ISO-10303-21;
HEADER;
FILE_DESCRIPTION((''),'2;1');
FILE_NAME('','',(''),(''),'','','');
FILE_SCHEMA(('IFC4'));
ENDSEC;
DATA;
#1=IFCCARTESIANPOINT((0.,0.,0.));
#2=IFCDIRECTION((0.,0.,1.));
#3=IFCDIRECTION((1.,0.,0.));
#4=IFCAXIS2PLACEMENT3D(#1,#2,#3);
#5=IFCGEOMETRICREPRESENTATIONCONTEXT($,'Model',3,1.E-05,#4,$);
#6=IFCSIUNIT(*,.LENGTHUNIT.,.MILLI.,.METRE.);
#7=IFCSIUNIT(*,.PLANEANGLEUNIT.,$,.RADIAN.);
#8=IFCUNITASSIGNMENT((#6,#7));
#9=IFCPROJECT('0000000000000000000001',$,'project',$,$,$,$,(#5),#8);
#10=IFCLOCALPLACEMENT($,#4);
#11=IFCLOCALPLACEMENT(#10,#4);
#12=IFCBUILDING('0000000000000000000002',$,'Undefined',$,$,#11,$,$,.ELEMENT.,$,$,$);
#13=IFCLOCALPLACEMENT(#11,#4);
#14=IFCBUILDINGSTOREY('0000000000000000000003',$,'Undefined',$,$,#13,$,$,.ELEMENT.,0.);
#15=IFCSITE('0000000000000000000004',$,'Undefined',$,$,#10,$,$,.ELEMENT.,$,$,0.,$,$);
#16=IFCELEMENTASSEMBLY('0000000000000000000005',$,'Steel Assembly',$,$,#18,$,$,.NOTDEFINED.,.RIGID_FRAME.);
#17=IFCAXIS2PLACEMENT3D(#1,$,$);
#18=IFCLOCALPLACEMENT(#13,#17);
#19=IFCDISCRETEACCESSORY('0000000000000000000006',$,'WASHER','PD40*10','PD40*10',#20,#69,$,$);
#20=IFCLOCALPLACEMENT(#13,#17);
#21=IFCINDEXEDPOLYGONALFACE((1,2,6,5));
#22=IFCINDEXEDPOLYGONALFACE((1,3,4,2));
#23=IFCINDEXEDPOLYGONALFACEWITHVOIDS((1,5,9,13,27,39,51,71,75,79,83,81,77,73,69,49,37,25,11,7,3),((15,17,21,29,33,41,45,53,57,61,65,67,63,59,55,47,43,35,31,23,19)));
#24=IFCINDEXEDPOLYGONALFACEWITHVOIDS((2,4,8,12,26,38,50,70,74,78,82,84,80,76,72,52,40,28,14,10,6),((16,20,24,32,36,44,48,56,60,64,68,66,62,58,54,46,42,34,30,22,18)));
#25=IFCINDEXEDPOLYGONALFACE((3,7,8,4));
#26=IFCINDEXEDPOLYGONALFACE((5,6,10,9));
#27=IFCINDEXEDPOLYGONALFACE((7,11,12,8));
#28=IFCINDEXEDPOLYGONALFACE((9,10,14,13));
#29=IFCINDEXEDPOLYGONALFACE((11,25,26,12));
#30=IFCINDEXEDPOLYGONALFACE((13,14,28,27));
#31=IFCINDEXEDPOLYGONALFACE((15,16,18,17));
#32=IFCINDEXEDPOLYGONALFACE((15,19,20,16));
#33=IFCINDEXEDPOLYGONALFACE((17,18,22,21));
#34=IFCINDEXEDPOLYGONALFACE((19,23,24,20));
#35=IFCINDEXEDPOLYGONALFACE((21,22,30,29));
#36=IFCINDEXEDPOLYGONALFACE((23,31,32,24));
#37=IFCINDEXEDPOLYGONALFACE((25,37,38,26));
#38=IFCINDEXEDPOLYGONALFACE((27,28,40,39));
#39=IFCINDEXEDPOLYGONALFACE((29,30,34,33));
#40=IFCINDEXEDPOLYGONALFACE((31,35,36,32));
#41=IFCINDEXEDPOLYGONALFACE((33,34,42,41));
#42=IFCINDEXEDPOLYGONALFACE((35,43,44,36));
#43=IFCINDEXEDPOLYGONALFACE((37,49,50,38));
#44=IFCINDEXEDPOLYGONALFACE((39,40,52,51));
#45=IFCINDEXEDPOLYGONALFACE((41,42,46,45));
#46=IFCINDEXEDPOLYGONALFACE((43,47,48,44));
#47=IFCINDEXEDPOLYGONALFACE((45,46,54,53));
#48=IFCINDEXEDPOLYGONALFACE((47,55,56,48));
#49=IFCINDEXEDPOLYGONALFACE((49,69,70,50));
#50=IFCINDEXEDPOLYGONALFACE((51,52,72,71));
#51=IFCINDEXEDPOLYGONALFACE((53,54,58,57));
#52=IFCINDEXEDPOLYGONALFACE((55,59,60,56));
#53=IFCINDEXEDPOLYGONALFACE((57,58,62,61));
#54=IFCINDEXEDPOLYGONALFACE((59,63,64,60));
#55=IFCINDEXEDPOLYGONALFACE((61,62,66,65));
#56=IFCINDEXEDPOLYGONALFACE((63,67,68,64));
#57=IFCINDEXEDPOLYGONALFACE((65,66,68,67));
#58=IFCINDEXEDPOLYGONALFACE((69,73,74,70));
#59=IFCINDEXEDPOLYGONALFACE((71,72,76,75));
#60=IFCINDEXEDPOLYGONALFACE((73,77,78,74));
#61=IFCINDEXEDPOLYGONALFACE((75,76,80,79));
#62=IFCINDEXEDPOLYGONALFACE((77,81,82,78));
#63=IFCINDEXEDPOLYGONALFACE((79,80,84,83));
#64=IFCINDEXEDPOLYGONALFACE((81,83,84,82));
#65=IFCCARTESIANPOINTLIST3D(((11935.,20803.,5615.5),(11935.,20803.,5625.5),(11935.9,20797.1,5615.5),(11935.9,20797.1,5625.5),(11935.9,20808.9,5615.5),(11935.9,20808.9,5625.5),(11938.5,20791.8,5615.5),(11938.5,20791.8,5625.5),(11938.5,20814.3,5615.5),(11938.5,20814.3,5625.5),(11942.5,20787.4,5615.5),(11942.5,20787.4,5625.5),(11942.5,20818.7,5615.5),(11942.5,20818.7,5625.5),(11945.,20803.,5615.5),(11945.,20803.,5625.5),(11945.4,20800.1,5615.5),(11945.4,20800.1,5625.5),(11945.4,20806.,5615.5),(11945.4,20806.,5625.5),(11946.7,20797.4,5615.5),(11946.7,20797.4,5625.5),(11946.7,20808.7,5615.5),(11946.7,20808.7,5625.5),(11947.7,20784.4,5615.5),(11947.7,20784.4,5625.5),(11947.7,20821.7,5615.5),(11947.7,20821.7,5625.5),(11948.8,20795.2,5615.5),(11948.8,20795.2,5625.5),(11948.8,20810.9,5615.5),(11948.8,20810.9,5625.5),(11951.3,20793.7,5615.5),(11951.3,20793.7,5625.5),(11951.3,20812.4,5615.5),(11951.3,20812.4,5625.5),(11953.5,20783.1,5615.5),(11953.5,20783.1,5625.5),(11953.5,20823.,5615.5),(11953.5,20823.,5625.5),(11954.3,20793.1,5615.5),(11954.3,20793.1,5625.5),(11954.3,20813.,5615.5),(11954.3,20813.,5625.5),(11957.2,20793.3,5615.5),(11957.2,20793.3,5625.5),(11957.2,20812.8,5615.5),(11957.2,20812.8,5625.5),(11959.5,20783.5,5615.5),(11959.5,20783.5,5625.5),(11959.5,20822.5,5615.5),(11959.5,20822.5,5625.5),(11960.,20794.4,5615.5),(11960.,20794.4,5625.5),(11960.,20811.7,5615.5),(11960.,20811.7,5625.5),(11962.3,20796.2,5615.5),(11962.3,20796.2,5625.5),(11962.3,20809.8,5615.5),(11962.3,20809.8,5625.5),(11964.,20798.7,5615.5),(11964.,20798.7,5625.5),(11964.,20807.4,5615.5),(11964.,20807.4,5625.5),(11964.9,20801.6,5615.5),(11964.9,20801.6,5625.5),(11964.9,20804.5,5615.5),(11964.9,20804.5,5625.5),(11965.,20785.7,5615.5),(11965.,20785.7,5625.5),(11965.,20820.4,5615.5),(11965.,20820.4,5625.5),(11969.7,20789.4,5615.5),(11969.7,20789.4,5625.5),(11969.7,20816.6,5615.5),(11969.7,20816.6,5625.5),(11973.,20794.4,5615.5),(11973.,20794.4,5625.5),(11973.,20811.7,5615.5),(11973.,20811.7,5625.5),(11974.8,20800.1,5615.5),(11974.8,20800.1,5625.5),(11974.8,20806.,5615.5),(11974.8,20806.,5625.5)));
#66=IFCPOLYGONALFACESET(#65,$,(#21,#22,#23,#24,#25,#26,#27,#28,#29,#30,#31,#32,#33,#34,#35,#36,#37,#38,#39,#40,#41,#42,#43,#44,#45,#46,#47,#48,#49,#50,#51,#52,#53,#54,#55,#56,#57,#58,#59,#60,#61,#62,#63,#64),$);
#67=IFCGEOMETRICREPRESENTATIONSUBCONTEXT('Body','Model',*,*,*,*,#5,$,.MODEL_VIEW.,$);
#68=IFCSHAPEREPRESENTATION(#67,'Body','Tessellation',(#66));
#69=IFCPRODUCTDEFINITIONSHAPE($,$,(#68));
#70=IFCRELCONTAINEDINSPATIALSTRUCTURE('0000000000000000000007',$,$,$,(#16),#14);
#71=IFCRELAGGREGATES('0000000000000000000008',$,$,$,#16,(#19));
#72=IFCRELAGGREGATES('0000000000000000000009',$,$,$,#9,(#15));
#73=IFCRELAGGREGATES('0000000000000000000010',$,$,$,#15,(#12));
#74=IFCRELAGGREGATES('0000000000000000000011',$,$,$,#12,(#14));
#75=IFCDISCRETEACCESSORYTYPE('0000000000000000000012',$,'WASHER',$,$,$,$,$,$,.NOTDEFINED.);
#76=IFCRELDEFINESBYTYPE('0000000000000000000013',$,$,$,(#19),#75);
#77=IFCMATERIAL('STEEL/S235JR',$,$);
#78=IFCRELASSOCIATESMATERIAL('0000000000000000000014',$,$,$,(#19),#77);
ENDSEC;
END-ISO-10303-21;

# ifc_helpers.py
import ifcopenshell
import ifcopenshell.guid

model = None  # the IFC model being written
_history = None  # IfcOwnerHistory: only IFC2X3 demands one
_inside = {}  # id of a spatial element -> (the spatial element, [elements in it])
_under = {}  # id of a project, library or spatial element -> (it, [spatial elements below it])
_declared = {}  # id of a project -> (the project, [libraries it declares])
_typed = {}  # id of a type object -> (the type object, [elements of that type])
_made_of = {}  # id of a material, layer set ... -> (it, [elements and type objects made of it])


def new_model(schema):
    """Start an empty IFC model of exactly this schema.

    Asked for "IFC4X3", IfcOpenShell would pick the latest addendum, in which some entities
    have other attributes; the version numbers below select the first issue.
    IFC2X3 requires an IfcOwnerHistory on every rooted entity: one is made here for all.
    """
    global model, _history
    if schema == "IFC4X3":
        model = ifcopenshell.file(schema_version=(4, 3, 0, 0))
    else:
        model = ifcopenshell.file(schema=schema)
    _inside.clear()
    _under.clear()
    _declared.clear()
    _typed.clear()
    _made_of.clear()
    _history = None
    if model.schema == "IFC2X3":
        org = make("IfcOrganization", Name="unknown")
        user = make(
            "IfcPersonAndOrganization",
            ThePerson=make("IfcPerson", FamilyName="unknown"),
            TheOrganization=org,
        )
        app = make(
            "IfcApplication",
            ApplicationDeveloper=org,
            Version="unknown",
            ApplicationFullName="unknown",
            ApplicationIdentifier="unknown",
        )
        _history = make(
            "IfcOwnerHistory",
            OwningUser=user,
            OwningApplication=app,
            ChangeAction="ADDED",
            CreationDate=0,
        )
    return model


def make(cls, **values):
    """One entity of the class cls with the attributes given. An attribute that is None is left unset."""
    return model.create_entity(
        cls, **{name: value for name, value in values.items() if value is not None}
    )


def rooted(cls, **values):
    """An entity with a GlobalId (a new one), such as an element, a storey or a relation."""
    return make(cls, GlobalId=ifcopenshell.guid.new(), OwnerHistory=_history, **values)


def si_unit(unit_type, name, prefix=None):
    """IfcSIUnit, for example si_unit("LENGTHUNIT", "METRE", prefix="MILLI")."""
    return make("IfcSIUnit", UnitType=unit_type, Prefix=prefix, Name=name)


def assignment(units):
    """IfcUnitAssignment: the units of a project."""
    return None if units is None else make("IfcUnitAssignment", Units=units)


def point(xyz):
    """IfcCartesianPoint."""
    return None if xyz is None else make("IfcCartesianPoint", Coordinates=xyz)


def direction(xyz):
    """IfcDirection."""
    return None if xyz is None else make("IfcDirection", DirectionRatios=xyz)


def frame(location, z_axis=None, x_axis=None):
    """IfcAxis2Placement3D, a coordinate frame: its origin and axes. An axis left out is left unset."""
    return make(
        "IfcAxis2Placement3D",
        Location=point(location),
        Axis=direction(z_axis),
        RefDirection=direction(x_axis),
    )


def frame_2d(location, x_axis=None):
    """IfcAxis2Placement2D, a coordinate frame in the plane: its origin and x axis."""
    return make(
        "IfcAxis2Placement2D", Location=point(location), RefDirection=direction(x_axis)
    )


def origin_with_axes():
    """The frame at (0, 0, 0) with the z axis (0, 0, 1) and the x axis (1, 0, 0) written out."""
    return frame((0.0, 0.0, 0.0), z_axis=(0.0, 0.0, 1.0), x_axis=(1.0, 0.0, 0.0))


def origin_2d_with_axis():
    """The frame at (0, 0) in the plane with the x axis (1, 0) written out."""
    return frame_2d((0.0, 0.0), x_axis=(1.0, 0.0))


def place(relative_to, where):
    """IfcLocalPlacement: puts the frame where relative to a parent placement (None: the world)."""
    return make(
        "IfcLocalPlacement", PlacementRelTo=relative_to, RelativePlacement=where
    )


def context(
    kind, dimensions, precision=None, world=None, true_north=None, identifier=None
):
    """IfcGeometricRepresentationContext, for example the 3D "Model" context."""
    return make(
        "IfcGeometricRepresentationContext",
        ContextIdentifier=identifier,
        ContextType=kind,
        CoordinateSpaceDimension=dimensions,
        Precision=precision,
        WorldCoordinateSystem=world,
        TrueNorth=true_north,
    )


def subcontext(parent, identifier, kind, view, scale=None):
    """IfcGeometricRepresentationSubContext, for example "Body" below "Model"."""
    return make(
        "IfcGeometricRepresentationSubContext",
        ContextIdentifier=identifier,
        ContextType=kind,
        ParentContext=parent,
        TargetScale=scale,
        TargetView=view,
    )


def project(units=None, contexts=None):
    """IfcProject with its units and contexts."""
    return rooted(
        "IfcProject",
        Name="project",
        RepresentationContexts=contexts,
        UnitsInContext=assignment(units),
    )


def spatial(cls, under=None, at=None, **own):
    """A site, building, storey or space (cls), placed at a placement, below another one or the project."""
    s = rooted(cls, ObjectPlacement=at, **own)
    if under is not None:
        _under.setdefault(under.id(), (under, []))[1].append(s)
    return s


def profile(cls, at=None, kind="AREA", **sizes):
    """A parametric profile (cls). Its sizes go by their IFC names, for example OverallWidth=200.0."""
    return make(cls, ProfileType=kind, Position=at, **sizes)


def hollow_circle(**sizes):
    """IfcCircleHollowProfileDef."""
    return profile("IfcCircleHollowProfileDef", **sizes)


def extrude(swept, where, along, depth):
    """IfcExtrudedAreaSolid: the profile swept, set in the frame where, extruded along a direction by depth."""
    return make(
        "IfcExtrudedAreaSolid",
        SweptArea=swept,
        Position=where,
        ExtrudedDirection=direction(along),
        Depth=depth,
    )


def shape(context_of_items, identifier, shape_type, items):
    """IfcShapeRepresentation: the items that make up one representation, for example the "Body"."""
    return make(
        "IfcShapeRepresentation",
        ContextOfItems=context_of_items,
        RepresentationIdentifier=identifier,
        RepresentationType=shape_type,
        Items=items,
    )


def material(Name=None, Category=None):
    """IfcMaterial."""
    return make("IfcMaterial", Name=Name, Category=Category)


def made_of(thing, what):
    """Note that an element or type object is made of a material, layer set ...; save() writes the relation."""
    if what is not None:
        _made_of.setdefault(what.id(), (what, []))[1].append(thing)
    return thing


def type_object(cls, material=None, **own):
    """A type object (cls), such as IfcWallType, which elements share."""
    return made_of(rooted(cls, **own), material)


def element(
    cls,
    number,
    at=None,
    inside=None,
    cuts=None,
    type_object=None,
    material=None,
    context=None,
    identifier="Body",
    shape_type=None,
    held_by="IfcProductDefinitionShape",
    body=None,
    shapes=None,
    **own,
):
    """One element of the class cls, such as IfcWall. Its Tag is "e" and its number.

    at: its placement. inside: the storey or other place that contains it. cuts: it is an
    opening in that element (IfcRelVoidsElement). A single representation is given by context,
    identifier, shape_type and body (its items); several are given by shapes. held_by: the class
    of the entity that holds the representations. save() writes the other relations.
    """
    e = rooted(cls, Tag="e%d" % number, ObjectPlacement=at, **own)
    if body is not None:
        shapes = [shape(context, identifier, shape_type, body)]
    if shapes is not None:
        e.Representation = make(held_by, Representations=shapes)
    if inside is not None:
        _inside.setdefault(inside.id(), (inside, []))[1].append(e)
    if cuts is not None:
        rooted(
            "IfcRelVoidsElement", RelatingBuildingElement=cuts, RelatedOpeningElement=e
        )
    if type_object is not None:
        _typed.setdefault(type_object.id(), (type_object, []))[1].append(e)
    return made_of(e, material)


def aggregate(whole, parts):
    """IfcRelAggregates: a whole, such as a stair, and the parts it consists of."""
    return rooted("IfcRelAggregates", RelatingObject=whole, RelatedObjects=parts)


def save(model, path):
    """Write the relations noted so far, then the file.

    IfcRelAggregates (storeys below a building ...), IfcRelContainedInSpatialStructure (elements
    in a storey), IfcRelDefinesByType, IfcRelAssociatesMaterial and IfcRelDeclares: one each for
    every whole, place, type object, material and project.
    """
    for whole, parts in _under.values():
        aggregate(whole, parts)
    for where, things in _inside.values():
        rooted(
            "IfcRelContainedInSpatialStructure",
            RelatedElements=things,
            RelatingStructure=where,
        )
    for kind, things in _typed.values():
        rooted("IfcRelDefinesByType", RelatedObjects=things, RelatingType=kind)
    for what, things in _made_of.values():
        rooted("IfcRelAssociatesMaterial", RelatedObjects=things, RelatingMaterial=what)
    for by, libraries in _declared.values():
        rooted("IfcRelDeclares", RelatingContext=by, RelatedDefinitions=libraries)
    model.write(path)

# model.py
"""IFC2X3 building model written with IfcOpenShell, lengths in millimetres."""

from ifc_helpers import new_model, si_unit, frame, origin_with_axes, origin_2d_with_axis, place, context, subcontext, project, spatial, hollow_circle, extrude, material, type_object, element, aggregate, save


model = new_model("IFC2X3")

# Units and contexts
model_context = context("Model", 3, precision=1e-05, world=origin_with_axes())
body_context = subcontext(model_context, "Body", "Model", "MODEL_VIEW")
ifc_project = project(units=[si_unit("LENGTHUNIT", "METRE", prefix="MILLI"), si_unit("PLANEANGLEUNIT", "RADIAN")], contexts=[model_context])

# Site, building, storey
site_placement = place(None, origin_with_axes())
site = spatial("IfcSite", under=ifc_project, at=site_placement, Name="Undefined", CompositionType="ELEMENT", RefElevation=0.0)
building_placement = place(site_placement, origin_with_axes())
building = spatial("IfcBuilding", under=site, at=building_placement, Name="Undefined", CompositionType="ELEMENT")
storey_placement = place(building_placement, origin_with_axes())
storey = spatial("IfcBuildingStorey", under=building, at=storey_placement, Name="Undefined", CompositionType="ELEMENT", Elevation=0.0)

# Shared definitions
ifc_material_1 = material(Name="STEEL/S235JR")

# Element assembly
assembly_1_placement = place(storey_placement, origin_with_axes())
assembly_1 = element("IfcElementAssembly", 1, at=assembly_1_placement, inside=storey, Name="Steel Assembly", AssemblyPlace="NOTDEFINED", PredefinedType="RIGID_FRAME")

# Discrete accessory
discrete_accessory_type_1 = type_object("IfcDiscreteAccessoryType", Name="WASHER")
discrete_accessory_1_placement = place(assembly_1_placement, frame((11955.0, 20803.0, 5625.5), z_axis=(0.0, -1.0, 0.0), x_axis=(0.0, 0.0, -1.0)))
discrete_accessory_1 = element("IfcDiscreteAccessory", 2, at=discrete_accessory_1_placement, type_object=discrete_accessory_type_1, material=ifc_material_1, Name="WASHER", Description="PD40*10", ObjectType="PD40*10", context=body_context, shape_type="SweptSolid", body=[
    extrude(hollow_circle(Radius=20.0, WallThickness=10.0, at=origin_2d_with_axis()), frame((10.0, 0.0, 0.0), z_axis=(-1.0, 0.0, 0.0), x_axis=(0.0, -1.0, 0.0)), (0.0, 0.0, 1.0), 10.0),
])
aggregate(assembly_1, [discrete_accessory_1])

save(model, "model.ifc")
